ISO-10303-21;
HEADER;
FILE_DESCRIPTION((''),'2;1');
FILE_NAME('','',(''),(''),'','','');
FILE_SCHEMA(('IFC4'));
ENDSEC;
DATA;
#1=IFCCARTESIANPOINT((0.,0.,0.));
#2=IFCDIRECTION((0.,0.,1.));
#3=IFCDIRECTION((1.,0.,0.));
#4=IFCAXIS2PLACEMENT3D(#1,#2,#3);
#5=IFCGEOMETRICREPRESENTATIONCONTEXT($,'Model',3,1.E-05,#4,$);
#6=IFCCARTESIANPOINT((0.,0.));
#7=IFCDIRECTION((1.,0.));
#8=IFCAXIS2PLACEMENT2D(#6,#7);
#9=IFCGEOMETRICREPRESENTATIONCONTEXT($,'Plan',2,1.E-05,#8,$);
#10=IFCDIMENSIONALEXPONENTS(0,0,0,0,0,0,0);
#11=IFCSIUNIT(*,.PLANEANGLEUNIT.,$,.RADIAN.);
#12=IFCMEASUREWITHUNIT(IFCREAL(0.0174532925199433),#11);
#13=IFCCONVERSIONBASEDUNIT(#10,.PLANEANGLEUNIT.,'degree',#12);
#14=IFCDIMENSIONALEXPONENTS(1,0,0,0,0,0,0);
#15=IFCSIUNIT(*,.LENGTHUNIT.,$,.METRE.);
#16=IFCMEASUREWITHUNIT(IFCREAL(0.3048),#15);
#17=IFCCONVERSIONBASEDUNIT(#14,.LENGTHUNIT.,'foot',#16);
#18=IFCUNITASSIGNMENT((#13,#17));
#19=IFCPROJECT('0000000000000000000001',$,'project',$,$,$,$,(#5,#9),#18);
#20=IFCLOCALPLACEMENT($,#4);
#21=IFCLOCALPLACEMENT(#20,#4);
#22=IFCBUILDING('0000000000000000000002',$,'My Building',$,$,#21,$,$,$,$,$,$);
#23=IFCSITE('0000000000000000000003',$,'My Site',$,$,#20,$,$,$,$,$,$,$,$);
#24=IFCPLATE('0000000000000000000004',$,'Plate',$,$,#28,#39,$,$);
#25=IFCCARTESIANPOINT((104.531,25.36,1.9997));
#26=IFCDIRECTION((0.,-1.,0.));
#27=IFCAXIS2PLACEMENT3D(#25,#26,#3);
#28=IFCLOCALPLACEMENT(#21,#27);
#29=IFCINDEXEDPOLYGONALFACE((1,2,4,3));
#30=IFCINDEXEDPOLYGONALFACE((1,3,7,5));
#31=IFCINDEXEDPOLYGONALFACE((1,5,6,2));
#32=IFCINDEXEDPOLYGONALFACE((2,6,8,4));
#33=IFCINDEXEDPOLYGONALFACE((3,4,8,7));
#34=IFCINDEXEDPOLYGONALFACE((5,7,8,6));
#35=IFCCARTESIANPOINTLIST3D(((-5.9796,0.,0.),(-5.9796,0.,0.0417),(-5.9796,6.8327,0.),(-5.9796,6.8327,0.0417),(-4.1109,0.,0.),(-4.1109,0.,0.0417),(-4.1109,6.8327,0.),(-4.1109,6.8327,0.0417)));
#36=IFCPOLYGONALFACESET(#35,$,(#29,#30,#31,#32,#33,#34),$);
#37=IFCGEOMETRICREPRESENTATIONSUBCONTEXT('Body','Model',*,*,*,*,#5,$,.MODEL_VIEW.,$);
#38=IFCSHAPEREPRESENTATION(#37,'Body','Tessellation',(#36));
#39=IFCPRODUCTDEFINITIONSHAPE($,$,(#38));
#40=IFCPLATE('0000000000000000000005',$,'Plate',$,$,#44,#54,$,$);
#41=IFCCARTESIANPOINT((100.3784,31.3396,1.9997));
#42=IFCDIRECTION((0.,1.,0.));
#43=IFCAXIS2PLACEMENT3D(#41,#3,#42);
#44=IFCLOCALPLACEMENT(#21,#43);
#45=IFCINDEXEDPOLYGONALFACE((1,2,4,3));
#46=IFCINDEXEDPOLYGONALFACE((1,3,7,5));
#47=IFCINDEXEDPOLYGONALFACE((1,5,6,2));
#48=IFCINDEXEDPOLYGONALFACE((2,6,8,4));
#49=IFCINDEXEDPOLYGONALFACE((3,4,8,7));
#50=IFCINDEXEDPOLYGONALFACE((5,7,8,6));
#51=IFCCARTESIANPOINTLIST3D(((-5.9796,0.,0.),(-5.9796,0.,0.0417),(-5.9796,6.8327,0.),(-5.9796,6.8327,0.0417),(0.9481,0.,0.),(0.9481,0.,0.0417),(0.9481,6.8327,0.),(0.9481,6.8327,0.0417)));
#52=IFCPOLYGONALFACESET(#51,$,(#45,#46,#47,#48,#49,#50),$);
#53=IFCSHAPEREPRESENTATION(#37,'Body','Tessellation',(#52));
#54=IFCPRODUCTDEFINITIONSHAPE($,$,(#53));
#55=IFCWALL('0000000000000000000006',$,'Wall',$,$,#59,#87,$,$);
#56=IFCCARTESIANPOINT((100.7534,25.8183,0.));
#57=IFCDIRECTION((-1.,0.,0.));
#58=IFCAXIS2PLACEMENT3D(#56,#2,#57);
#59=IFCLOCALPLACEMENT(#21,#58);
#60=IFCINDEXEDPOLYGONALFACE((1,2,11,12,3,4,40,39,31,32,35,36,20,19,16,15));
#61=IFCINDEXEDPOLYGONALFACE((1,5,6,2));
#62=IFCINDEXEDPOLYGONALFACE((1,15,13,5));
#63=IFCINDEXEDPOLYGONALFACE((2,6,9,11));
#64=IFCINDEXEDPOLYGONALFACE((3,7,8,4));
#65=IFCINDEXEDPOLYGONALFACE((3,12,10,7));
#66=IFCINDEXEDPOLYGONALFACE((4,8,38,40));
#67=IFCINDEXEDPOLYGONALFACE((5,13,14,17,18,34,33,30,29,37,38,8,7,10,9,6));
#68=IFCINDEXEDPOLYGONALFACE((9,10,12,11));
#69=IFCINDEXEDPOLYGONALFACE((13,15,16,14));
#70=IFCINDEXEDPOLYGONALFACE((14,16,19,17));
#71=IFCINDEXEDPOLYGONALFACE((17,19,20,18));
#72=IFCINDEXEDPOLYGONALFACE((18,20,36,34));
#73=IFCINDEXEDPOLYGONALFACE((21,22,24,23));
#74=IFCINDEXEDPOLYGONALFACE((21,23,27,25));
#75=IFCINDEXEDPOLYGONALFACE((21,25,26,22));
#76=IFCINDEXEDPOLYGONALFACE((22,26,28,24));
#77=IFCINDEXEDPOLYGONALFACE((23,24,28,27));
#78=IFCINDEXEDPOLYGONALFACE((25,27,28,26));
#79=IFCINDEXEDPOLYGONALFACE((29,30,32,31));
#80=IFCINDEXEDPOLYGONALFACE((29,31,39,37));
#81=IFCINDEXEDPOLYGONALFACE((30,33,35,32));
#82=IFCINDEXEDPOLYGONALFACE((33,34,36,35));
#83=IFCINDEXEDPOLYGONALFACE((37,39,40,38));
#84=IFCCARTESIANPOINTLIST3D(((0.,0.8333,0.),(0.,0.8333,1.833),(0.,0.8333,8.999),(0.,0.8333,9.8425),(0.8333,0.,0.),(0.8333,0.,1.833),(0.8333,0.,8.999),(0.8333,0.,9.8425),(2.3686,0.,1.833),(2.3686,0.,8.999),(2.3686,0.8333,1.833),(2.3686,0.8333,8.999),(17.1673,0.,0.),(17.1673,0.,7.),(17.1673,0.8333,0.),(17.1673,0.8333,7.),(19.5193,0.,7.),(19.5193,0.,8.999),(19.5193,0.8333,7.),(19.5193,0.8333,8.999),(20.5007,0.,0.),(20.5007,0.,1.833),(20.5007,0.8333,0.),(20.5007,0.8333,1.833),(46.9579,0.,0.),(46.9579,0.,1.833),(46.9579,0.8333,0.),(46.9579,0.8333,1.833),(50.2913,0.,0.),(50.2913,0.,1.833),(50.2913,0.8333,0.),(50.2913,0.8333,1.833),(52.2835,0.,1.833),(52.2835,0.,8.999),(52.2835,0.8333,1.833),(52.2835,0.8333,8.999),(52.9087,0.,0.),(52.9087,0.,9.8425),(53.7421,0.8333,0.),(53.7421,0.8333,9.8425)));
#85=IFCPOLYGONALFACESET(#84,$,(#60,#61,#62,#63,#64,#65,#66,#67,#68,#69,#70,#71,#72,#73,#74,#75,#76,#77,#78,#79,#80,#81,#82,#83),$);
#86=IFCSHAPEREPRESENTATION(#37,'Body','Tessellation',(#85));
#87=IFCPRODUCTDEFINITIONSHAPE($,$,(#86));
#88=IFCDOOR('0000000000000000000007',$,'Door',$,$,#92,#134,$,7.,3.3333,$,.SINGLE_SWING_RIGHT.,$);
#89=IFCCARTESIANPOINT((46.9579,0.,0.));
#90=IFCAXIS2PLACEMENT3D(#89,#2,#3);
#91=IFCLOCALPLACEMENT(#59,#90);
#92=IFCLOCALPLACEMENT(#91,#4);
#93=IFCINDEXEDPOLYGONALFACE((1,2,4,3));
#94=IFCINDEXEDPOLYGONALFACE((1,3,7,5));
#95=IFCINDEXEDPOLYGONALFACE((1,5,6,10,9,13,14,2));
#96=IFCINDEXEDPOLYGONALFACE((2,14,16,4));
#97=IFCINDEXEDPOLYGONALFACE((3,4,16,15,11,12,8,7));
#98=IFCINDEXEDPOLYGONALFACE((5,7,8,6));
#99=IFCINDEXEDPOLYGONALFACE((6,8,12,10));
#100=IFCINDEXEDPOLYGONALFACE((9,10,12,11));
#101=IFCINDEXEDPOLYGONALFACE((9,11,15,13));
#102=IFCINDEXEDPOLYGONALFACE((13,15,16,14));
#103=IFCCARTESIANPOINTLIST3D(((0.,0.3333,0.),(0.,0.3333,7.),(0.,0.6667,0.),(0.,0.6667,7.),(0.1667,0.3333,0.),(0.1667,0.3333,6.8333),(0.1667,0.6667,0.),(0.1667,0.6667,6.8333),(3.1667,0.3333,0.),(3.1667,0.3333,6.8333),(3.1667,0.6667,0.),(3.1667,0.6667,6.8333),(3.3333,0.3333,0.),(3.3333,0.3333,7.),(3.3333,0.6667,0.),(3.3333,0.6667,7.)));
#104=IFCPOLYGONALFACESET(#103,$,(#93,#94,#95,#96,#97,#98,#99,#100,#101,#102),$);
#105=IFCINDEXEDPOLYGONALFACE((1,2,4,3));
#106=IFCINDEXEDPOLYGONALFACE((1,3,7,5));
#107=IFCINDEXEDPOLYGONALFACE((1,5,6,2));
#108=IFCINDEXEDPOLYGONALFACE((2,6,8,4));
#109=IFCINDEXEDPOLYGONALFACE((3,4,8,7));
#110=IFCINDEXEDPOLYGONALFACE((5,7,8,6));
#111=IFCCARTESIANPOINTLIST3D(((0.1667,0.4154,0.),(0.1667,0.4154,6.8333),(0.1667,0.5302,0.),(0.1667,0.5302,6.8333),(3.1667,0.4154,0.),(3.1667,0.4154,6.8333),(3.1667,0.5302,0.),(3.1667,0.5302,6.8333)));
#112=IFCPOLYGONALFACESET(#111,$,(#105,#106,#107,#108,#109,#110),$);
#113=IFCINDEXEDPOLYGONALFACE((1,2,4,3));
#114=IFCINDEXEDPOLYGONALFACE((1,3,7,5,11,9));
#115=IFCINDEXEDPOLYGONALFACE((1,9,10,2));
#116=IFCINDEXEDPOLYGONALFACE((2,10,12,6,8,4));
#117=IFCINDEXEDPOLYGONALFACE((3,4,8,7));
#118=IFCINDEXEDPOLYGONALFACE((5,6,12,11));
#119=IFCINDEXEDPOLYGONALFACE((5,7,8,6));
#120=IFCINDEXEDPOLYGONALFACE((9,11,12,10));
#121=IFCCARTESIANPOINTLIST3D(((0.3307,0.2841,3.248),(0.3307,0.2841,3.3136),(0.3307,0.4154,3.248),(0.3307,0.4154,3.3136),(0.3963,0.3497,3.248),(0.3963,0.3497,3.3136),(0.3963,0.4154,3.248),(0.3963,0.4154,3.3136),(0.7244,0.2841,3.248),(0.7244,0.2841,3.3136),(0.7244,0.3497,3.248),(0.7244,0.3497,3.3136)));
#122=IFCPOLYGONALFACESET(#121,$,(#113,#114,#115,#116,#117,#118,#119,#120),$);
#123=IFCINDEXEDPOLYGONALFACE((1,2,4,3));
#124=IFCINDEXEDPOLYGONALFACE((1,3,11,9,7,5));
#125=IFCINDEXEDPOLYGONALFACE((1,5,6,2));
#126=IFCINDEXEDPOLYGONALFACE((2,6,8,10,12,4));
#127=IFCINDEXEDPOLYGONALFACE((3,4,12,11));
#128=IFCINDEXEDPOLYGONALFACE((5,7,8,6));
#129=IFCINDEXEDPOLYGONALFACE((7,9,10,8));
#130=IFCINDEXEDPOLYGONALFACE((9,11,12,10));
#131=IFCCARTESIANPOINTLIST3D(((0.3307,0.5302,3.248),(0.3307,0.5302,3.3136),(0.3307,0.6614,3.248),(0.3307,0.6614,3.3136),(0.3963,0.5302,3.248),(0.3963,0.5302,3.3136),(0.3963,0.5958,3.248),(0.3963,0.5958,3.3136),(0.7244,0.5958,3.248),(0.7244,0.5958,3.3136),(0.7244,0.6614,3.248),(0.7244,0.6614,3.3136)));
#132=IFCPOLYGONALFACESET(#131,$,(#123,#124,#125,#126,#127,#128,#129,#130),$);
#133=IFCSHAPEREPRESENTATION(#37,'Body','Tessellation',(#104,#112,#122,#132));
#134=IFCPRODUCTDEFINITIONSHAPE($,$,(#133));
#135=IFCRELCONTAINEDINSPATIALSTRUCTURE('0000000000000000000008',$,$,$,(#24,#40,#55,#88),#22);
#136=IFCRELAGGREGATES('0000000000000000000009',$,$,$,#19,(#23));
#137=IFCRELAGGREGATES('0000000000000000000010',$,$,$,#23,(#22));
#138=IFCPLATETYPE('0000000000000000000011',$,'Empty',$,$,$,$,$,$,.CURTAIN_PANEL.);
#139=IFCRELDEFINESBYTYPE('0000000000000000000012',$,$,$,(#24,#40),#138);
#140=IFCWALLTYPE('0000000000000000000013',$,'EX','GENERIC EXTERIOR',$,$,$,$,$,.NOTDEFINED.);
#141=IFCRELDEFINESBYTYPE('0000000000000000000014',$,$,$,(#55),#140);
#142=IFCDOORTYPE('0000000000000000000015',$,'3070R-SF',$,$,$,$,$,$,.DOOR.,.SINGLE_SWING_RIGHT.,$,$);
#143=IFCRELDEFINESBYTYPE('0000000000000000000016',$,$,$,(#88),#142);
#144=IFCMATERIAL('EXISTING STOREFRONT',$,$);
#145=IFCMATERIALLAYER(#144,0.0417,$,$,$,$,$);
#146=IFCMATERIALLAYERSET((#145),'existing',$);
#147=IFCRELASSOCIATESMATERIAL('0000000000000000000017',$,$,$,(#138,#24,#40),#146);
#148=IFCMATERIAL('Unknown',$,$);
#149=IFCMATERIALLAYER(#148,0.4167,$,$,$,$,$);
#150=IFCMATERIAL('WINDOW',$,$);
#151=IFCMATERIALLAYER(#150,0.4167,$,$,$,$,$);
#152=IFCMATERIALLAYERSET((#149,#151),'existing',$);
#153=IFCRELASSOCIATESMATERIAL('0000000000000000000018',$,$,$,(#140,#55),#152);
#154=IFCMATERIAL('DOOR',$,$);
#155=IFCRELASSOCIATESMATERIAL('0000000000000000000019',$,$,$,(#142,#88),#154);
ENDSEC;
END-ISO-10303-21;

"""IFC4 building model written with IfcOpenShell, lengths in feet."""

from ifc_helpers import new_model, entity, si_unit, converted_unit, frame, origin_with_axes, origin_2d_with_axis, place, context, subcontext, project, spatial, polyline, line, indexed_curve, outline, extrude, clip, halfspace, shape, source, transform, mapped, material, layer, layer_set, layer_usage, type_object, type_shapes, element, fill, save


model = new_model("IFC4")

# Units and contexts
model_context = context("Model", 3, precision=1e-05, world=origin_with_axes())
plan_context = context("Plan", 2, precision=1e-05, world=origin_2d_with_axis())
body_context_1 = subcontext(model_context, "Body", "Model", "MODEL_VIEW")
body_context_2 = subcontext(plan_context, "Body", "Plan", "PLAN_VIEW")
ifc_project = project(units=[converted_unit("PLANEANGLEUNIT", "degree", entity("IfcReal", 0.0174532925199433), si_unit("PLANEANGLEUNIT", "RADIAN"), dimensions=[0, 0, 0, 0, 0, 0, 0]), converted_unit("LENGTHUNIT", "foot", entity("IfcReal", 0.3048), si_unit("LENGTHUNIT", "METRE"), dimensions=[1, 0, 0, 0, 0, 0, 0])], contexts=[model_context, plan_context])

# Site, building
site_placement = place(None, origin_with_axes())
site = spatial("IfcSite", under=ifc_project, at=site_placement, Name="My Site")
building_placement = place(site_placement, origin_with_axes())
building = spatial("IfcBuilding", under=site, at=building_placement, Name="My Building")

# Plates
ifc_material_1 = material(Name="EXISTING STOREFRONT")
ifc_layer_1 = layer(ifc_material_1, 0.0417)
ifc_layer_set_1 = layer_set([ifc_layer_1], Name="existing")
ifc_layer_usage_1 = layer_usage(ifc_layer_set_1, "AXIS3", "POSITIVE", 0.0)
plate_type = type_object("IfcPlateType", Name="Empty", PredefinedType="CURTAIN_PANEL", material=ifc_layer_set_1)
plate_1_placement = place(building_placement, frame((104.531, 25.36, 1.9997), z_axis=(0.0, -1.0, 0.0), x_axis=(1.0, 0.0, 0.0)))
element("IfcPlate", 1, at=plate_1_placement, inside=building, type_object=plate_type, material=ifc_layer_usage_1, Name="Plate", context=body_context_1, shape_type="SweptSolid", body=[
    extrude(outline(indexed_curve([(-5.9796, 6.8327), (-4.1109, 6.8327), (-4.1109, 0.0), (-5.9796, 0.0)], segments=[line(4, 1), line(1, 2), line(2, 3), line(3, 4)], self_intersect=False)), None, (0.0, 0.0, 1.0), 0.0417),
])
ifc_layer_usage_2 = layer_usage(ifc_layer_set_1, "AXIS3", "POSITIVE", 0.0)
plate_2_placement = place(building_placement, frame((100.3784, 31.3396, 1.9997), z_axis=(1.0, 0.0, 0.0), x_axis=(0.0, 1.0, 0.0)))
element("IfcPlate", 2, at=plate_2_placement, inside=building, type_object=plate_type, material=ifc_layer_usage_2, Name="Plate", context=body_context_1, shape_type="SweptSolid", body=[
    extrude(outline(indexed_curve([(-5.9796, 6.8327), (0.9481, 6.8327), (0.9481, 0.0), (-5.9796, 0.0)], segments=[line(4, 1), line(1, 2), line(2, 3), line(3, 4)], self_intersect=False)), None, (0.0, 0.0, 1.0), 0.0417),
])

# Wall, openings, door
ifc_material_2 = material(Name="Unknown")
ifc_layer_2 = layer(ifc_material_2, 0.4167)
ifc_material_3 = material(Name="WINDOW")
ifc_layer_3 = layer(ifc_material_3, 0.4167)
ifc_layer_set_2 = layer_set([ifc_layer_2, ifc_layer_3], Name="existing")
ifc_layer_usage_3 = layer_usage(ifc_layer_set_2, "AXIS2", "POSITIVE", 0.0)
wall_type_1 = type_object("IfcWallType", Name="EX", Description="GENERIC EXTERIOR", PredefinedType="NOTDEFINED", material=ifc_layer_set_2)
wall_1_placement = place(building_placement, frame((100.7534, 25.8183, 0.0), z_axis=(0.0, 0.0, 1.0), x_axis=(-1.0, 0.0, 0.0)))
wall_1 = element("IfcWall", 3, at=wall_1_placement, inside=building, type_object=wall_type_1, material=ifc_layer_usage_3, Name="Wall", context=body_context_1, shape_type="Clipping", body=[
    clip(clip(extrude(outline(indexed_curve([(0.0, 0.0), (0.0, 0.8333), (53.7421, 0.8333), (53.7421, 0.0), (0.0, 0.0)], self_intersect=False)), origin_with_axes(), (0.0, 0.0, 1.0), 9.8425), halfspace(frame((0.8333, 0.0, 0.0), z_axis=(-0.762, -0.761999, 0.0), x_axis=(-0.254, 0.254, 0.0)), False)), halfspace(frame((52.9087, 0.0, 0.0), z_axis=(0.761999, -0.762002, 0.0), x_axis=(0.254001, 0.254, 0.0)), False)),
])
shared_shape_1 = source(origin_with_axes(), body_context_1, "Body", "SweptSolid", [
    extrude(outline(indexed_curve([(0.0, 0.0), (3.3333, 0.0), (3.3333, 7.0), (0.0, 7.0)], segments=[line(1, 2), line(2, 3), line(3, 4), line(4, 1)])), frame((0.0, -0.3281, 0.0), z_axis=(0.0, -1.0, 0.0), x_axis=(1.0, 0.0, 0.0)), (0.0, 0.0, -1.0), 1.4895),
])
opening_1_placement = place(wall_1_placement, frame((17.1673, 0.0, 0.0), z_axis=(0.0, 0.0, 1.0), x_axis=(1.0, 0.0, 0.0)))
element("IfcOpeningElement", 4, at=opening_1_placement, cuts=wall_1, PredefinedType="OPENING", context=body_context_1, shape_type="MappedRepresentation", body=[
    mapped(shared_shape_1, transform((0.0, 0.0, 0.0), x_axis=(1.0, 0.0, 0.0), y_axis=(0.0, 1.0, 0.0), z_axis=(0.0, 0.0, 1.0), scale=1.0)),
])
shared_shape_2 = source(origin_with_axes(), body_context_1, "Body", "SweptSolid", [
    extrude(outline(indexed_curve([(0.0, 0.0), (3.3333, 0.0), (3.3333, 7.0), (0.0, 7.0)], segments=[line(1, 2), line(2, 3), line(3, 4), line(4, 1)])), frame((0.0, -0.3281, 0.0), z_axis=(0.0, -1.0, 0.0), x_axis=(1.0, 0.0, 0.0)), (0.0, 0.0, -1.0), 1.4895),
])
opening_2_placement = place(wall_1_placement, frame((46.9579, 0.0, 0.0), z_axis=(0.0, 0.0, 1.0), x_axis=(1.0, 0.0, 0.0)))
opening_2 = element("IfcOpeningElement", 5, at=opening_2_placement, cuts=wall_1, PredefinedType="OPENING", context=body_context_1, shape_type="MappedRepresentation", body=[
    mapped(shared_shape_2, transform((0.0, 0.0, 0.0), x_axis=(1.0, 0.0, 0.0), y_axis=(0.0, 1.0, 0.0), z_axis=(0.0, 0.0, 1.0), scale=1.0)),
])
opening_3_placement = place(wall_1_placement, frame((33.1323, 0.8333, 0.0), z_axis=(0.0, -1.0, 0.0), x_axis=(1.0, 0.0, 0.0)))
element("IfcOpeningElement", 6, at=opening_3_placement, cuts=wall_1, context=body_context_1, shape_type="SweptSolid", body=[
    extrude(outline(indexed_curve([(-16.3821, -3.583), (16.3821, -3.583), (16.3821, 3.583), (-16.3821, 3.583)], segments=[line(3, 2), line(2, 1), line(1, 4), line(4, 3)], self_intersect=False)), frame((2.7691, 5.416, -0.8202), z_axis=(0.0, 0.0, -1.0), x_axis=(1.0, 0.0, 0.0)), (0.0, 0.0, -1.0), 2.0263),
])
opening_4_placement = place(wall_1_placement, frame((-5.3064, 0.8333, 0.0), z_axis=(0.0, -1.0, 0.0), x_axis=(1.0, 0.0, 0.0)))
element("IfcOpeningElement", 7, at=opening_4_placement, cuts=wall_1, context=body_context_1, shape_type="SweptSolid", body=[
    extrude(outline(polyline([(-2.4823, -3.583), (2.4823, -3.583), (2.4823, 3.583), (-2.4823, 3.583), (-2.4823, -3.583)])), frame((5.1928, 5.416, -0.8202), z_axis=(0.0, 0.0, -1.0), x_axis=(1.0, 0.0, 0.0)), (0.0, 0.0, -1.0), 2.0263),
])
ifc_material_4 = material(Name="DOOR")
door_type = type_object("IfcDoorType", Name="3070R-SF", OperationType="SINGLE_SWING_RIGHT", PredefinedType="DOOR", material=ifc_material_4)
shared_shape_3 = source(origin_with_axes(), body_context_1, "Body", "SweptSolid", [
    extrude(outline(indexed_curve([(0.0, 0.0), (0.0, 7.0), (3.3333, 7.0), (3.3333, 0.0), (3.1667, 0.0), (3.1667, 6.8333), (0.1667, 6.8333), (0.1667, 0.0)], segments=[line(1, 2), line(2, 3), line(3, 4), line(4, 5), line(5, 6), line(6, 7), line(7, 8), line(8, 1)])), frame((0.0, 0.3333, 0.0), z_axis=(0.0, -1.0, 0.0), x_axis=(1.0, 0.0, 0.0)), (0.0, 0.0, -1.0), 0.3333),
    extrude(outline(indexed_curve([(0.0, 0.0), (3.0, 0.0), (3.0, 0.1148), (0.0, 0.1148)], segments=[line(1, 2), line(2, 3), line(3, 4), line(4, 1)])), frame((0.1667, 0.4154, 0.0), z_axis=(0.0, 0.0, 1.0), x_axis=(1.0, 0.0, 0.0)), (0.0, 0.0, 1.0), 6.8333),
    extrude(outline(indexed_curve([(0.0, 0.0), (0.0, -0.1312), (0.3937, -0.1312), (0.3937, -0.0656), (0.0656, -0.0656), (0.0656, 0.0)], segments=[line(1, 2), line(2, 3), line(3, 4), line(4, 5), line(5, 6), line(6, 1)])), frame((0.3307, 0.4154, 3.248), z_axis=(0.0, 0.0, 1.0), x_axis=(1.0, 0.0, 0.0)), (0.0, 0.0, 1.0), 0.0656),
    extrude(outline(indexed_curve([(0.0, 0.0), (0.0, 0.1312), (0.3937, 0.1312), (0.3937, 0.0656), (0.0656, 0.0656), (0.0656, 0.0)], segments=[line(1, 2), line(2, 3), line(3, 4), line(4, 5), line(5, 6), line(6, 1)])), frame((0.3307, 0.5302, 3.248), z_axis=(0.0, 0.0, 1.0), x_axis=(1.0, 0.0, 0.0)), (0.0, 0.0, 1.0), 0.0656),
])
shared_shape_4 = source(origin_with_axes(), body_context_2, "Body", "Curve2D", [
    entity("IfcIndexedPolyCurve", entity("IfcCartesianPointList2D", [[0.0, 0.3333], [0.1667, 0.3333], [0.1667, 0.6667], [0.0, 0.6667]]), [entity("IfcLineIndex", [1, 2]), entity("IfcLineIndex", [2, 3]), entity("IfcLineIndex", [3, 4]), entity("IfcLineIndex", [4, 1])]),
    entity("IfcIndexedPolyCurve", entity("IfcCartesianPointList2D", [[3.3333, 0.3333], [3.1667, 0.3333], [3.1667, 0.6667], [3.3333, 0.6667]]), [entity("IfcLineIndex", [1, 2]), entity("IfcLineIndex", [2, 3]), entity("IfcLineIndex", [3, 4]), entity("IfcLineIndex", [4, 1])]),
    entity("IfcTrimmedCurve", entity("IfcEllipse", entity("IfcAxis2Placement2D", entity("IfcCartesianPoint", [3.0518, 0.6667]), entity("IfcDirection", [1.0, 0.0])), 2.8852, 3.0), [entity("IfcCartesianPoint", [3.0518, 3.6667])], [entity("IfcCartesianPoint", [0.1667, 0.6667])], True, "CARTESIAN"),
    entity("IfcIndexedPolyCurve", entity("IfcCartesianPointList2D", [[3.1667, 0.6667], [3.0518, 0.6667], [3.0518, 3.6667], [3.1667, 3.6667]]), [entity("IfcLineIndex", [1, 2]), entity("IfcLineIndex", [2, 3]), entity("IfcLineIndex", [3, 4]), entity("IfcLineIndex", [4, 1])]),
])
type_shapes(door_type, [shared_shape_3, shared_shape_4])
door_placement = place(opening_2_placement, frame((0.0, 0.0, 0.0), z_axis=(0.0, 0.0, 1.0), x_axis=(1.0, 0.0, 0.0)))
door = element("IfcDoor", 8, at=door_placement, inside=building, type_object=door_type, material=ifc_material_4, Name="Door", OperationType="SINGLE_SWING_RIGHT", OverallHeight=7.0, OverallWidth=3.3333, shapes=[
    shape(body_context_1, "Body", "MappedRepresentation", [mapped(shared_shape_3, transform((0.0, 0.0, 0.0), x_axis=(1.0, 0.0, 0.0), y_axis=(0.0, 1.0, 0.0), z_axis=(0.0, 0.0, 1.0), scale=1.0))]),
    shape(body_context_2, "Body", "MappedRepresentation", [mapped(shared_shape_4, transform((0.0, 0.0, 0.0), x_axis=(1.0, 0.0, 0.0), y_axis=(0.0, 1.0, 0.0), z_axis=(0.0, 0.0, 1.0), scale=1.0))]),
])
fill(opening_2, door)

save(model, "model.ifc")
